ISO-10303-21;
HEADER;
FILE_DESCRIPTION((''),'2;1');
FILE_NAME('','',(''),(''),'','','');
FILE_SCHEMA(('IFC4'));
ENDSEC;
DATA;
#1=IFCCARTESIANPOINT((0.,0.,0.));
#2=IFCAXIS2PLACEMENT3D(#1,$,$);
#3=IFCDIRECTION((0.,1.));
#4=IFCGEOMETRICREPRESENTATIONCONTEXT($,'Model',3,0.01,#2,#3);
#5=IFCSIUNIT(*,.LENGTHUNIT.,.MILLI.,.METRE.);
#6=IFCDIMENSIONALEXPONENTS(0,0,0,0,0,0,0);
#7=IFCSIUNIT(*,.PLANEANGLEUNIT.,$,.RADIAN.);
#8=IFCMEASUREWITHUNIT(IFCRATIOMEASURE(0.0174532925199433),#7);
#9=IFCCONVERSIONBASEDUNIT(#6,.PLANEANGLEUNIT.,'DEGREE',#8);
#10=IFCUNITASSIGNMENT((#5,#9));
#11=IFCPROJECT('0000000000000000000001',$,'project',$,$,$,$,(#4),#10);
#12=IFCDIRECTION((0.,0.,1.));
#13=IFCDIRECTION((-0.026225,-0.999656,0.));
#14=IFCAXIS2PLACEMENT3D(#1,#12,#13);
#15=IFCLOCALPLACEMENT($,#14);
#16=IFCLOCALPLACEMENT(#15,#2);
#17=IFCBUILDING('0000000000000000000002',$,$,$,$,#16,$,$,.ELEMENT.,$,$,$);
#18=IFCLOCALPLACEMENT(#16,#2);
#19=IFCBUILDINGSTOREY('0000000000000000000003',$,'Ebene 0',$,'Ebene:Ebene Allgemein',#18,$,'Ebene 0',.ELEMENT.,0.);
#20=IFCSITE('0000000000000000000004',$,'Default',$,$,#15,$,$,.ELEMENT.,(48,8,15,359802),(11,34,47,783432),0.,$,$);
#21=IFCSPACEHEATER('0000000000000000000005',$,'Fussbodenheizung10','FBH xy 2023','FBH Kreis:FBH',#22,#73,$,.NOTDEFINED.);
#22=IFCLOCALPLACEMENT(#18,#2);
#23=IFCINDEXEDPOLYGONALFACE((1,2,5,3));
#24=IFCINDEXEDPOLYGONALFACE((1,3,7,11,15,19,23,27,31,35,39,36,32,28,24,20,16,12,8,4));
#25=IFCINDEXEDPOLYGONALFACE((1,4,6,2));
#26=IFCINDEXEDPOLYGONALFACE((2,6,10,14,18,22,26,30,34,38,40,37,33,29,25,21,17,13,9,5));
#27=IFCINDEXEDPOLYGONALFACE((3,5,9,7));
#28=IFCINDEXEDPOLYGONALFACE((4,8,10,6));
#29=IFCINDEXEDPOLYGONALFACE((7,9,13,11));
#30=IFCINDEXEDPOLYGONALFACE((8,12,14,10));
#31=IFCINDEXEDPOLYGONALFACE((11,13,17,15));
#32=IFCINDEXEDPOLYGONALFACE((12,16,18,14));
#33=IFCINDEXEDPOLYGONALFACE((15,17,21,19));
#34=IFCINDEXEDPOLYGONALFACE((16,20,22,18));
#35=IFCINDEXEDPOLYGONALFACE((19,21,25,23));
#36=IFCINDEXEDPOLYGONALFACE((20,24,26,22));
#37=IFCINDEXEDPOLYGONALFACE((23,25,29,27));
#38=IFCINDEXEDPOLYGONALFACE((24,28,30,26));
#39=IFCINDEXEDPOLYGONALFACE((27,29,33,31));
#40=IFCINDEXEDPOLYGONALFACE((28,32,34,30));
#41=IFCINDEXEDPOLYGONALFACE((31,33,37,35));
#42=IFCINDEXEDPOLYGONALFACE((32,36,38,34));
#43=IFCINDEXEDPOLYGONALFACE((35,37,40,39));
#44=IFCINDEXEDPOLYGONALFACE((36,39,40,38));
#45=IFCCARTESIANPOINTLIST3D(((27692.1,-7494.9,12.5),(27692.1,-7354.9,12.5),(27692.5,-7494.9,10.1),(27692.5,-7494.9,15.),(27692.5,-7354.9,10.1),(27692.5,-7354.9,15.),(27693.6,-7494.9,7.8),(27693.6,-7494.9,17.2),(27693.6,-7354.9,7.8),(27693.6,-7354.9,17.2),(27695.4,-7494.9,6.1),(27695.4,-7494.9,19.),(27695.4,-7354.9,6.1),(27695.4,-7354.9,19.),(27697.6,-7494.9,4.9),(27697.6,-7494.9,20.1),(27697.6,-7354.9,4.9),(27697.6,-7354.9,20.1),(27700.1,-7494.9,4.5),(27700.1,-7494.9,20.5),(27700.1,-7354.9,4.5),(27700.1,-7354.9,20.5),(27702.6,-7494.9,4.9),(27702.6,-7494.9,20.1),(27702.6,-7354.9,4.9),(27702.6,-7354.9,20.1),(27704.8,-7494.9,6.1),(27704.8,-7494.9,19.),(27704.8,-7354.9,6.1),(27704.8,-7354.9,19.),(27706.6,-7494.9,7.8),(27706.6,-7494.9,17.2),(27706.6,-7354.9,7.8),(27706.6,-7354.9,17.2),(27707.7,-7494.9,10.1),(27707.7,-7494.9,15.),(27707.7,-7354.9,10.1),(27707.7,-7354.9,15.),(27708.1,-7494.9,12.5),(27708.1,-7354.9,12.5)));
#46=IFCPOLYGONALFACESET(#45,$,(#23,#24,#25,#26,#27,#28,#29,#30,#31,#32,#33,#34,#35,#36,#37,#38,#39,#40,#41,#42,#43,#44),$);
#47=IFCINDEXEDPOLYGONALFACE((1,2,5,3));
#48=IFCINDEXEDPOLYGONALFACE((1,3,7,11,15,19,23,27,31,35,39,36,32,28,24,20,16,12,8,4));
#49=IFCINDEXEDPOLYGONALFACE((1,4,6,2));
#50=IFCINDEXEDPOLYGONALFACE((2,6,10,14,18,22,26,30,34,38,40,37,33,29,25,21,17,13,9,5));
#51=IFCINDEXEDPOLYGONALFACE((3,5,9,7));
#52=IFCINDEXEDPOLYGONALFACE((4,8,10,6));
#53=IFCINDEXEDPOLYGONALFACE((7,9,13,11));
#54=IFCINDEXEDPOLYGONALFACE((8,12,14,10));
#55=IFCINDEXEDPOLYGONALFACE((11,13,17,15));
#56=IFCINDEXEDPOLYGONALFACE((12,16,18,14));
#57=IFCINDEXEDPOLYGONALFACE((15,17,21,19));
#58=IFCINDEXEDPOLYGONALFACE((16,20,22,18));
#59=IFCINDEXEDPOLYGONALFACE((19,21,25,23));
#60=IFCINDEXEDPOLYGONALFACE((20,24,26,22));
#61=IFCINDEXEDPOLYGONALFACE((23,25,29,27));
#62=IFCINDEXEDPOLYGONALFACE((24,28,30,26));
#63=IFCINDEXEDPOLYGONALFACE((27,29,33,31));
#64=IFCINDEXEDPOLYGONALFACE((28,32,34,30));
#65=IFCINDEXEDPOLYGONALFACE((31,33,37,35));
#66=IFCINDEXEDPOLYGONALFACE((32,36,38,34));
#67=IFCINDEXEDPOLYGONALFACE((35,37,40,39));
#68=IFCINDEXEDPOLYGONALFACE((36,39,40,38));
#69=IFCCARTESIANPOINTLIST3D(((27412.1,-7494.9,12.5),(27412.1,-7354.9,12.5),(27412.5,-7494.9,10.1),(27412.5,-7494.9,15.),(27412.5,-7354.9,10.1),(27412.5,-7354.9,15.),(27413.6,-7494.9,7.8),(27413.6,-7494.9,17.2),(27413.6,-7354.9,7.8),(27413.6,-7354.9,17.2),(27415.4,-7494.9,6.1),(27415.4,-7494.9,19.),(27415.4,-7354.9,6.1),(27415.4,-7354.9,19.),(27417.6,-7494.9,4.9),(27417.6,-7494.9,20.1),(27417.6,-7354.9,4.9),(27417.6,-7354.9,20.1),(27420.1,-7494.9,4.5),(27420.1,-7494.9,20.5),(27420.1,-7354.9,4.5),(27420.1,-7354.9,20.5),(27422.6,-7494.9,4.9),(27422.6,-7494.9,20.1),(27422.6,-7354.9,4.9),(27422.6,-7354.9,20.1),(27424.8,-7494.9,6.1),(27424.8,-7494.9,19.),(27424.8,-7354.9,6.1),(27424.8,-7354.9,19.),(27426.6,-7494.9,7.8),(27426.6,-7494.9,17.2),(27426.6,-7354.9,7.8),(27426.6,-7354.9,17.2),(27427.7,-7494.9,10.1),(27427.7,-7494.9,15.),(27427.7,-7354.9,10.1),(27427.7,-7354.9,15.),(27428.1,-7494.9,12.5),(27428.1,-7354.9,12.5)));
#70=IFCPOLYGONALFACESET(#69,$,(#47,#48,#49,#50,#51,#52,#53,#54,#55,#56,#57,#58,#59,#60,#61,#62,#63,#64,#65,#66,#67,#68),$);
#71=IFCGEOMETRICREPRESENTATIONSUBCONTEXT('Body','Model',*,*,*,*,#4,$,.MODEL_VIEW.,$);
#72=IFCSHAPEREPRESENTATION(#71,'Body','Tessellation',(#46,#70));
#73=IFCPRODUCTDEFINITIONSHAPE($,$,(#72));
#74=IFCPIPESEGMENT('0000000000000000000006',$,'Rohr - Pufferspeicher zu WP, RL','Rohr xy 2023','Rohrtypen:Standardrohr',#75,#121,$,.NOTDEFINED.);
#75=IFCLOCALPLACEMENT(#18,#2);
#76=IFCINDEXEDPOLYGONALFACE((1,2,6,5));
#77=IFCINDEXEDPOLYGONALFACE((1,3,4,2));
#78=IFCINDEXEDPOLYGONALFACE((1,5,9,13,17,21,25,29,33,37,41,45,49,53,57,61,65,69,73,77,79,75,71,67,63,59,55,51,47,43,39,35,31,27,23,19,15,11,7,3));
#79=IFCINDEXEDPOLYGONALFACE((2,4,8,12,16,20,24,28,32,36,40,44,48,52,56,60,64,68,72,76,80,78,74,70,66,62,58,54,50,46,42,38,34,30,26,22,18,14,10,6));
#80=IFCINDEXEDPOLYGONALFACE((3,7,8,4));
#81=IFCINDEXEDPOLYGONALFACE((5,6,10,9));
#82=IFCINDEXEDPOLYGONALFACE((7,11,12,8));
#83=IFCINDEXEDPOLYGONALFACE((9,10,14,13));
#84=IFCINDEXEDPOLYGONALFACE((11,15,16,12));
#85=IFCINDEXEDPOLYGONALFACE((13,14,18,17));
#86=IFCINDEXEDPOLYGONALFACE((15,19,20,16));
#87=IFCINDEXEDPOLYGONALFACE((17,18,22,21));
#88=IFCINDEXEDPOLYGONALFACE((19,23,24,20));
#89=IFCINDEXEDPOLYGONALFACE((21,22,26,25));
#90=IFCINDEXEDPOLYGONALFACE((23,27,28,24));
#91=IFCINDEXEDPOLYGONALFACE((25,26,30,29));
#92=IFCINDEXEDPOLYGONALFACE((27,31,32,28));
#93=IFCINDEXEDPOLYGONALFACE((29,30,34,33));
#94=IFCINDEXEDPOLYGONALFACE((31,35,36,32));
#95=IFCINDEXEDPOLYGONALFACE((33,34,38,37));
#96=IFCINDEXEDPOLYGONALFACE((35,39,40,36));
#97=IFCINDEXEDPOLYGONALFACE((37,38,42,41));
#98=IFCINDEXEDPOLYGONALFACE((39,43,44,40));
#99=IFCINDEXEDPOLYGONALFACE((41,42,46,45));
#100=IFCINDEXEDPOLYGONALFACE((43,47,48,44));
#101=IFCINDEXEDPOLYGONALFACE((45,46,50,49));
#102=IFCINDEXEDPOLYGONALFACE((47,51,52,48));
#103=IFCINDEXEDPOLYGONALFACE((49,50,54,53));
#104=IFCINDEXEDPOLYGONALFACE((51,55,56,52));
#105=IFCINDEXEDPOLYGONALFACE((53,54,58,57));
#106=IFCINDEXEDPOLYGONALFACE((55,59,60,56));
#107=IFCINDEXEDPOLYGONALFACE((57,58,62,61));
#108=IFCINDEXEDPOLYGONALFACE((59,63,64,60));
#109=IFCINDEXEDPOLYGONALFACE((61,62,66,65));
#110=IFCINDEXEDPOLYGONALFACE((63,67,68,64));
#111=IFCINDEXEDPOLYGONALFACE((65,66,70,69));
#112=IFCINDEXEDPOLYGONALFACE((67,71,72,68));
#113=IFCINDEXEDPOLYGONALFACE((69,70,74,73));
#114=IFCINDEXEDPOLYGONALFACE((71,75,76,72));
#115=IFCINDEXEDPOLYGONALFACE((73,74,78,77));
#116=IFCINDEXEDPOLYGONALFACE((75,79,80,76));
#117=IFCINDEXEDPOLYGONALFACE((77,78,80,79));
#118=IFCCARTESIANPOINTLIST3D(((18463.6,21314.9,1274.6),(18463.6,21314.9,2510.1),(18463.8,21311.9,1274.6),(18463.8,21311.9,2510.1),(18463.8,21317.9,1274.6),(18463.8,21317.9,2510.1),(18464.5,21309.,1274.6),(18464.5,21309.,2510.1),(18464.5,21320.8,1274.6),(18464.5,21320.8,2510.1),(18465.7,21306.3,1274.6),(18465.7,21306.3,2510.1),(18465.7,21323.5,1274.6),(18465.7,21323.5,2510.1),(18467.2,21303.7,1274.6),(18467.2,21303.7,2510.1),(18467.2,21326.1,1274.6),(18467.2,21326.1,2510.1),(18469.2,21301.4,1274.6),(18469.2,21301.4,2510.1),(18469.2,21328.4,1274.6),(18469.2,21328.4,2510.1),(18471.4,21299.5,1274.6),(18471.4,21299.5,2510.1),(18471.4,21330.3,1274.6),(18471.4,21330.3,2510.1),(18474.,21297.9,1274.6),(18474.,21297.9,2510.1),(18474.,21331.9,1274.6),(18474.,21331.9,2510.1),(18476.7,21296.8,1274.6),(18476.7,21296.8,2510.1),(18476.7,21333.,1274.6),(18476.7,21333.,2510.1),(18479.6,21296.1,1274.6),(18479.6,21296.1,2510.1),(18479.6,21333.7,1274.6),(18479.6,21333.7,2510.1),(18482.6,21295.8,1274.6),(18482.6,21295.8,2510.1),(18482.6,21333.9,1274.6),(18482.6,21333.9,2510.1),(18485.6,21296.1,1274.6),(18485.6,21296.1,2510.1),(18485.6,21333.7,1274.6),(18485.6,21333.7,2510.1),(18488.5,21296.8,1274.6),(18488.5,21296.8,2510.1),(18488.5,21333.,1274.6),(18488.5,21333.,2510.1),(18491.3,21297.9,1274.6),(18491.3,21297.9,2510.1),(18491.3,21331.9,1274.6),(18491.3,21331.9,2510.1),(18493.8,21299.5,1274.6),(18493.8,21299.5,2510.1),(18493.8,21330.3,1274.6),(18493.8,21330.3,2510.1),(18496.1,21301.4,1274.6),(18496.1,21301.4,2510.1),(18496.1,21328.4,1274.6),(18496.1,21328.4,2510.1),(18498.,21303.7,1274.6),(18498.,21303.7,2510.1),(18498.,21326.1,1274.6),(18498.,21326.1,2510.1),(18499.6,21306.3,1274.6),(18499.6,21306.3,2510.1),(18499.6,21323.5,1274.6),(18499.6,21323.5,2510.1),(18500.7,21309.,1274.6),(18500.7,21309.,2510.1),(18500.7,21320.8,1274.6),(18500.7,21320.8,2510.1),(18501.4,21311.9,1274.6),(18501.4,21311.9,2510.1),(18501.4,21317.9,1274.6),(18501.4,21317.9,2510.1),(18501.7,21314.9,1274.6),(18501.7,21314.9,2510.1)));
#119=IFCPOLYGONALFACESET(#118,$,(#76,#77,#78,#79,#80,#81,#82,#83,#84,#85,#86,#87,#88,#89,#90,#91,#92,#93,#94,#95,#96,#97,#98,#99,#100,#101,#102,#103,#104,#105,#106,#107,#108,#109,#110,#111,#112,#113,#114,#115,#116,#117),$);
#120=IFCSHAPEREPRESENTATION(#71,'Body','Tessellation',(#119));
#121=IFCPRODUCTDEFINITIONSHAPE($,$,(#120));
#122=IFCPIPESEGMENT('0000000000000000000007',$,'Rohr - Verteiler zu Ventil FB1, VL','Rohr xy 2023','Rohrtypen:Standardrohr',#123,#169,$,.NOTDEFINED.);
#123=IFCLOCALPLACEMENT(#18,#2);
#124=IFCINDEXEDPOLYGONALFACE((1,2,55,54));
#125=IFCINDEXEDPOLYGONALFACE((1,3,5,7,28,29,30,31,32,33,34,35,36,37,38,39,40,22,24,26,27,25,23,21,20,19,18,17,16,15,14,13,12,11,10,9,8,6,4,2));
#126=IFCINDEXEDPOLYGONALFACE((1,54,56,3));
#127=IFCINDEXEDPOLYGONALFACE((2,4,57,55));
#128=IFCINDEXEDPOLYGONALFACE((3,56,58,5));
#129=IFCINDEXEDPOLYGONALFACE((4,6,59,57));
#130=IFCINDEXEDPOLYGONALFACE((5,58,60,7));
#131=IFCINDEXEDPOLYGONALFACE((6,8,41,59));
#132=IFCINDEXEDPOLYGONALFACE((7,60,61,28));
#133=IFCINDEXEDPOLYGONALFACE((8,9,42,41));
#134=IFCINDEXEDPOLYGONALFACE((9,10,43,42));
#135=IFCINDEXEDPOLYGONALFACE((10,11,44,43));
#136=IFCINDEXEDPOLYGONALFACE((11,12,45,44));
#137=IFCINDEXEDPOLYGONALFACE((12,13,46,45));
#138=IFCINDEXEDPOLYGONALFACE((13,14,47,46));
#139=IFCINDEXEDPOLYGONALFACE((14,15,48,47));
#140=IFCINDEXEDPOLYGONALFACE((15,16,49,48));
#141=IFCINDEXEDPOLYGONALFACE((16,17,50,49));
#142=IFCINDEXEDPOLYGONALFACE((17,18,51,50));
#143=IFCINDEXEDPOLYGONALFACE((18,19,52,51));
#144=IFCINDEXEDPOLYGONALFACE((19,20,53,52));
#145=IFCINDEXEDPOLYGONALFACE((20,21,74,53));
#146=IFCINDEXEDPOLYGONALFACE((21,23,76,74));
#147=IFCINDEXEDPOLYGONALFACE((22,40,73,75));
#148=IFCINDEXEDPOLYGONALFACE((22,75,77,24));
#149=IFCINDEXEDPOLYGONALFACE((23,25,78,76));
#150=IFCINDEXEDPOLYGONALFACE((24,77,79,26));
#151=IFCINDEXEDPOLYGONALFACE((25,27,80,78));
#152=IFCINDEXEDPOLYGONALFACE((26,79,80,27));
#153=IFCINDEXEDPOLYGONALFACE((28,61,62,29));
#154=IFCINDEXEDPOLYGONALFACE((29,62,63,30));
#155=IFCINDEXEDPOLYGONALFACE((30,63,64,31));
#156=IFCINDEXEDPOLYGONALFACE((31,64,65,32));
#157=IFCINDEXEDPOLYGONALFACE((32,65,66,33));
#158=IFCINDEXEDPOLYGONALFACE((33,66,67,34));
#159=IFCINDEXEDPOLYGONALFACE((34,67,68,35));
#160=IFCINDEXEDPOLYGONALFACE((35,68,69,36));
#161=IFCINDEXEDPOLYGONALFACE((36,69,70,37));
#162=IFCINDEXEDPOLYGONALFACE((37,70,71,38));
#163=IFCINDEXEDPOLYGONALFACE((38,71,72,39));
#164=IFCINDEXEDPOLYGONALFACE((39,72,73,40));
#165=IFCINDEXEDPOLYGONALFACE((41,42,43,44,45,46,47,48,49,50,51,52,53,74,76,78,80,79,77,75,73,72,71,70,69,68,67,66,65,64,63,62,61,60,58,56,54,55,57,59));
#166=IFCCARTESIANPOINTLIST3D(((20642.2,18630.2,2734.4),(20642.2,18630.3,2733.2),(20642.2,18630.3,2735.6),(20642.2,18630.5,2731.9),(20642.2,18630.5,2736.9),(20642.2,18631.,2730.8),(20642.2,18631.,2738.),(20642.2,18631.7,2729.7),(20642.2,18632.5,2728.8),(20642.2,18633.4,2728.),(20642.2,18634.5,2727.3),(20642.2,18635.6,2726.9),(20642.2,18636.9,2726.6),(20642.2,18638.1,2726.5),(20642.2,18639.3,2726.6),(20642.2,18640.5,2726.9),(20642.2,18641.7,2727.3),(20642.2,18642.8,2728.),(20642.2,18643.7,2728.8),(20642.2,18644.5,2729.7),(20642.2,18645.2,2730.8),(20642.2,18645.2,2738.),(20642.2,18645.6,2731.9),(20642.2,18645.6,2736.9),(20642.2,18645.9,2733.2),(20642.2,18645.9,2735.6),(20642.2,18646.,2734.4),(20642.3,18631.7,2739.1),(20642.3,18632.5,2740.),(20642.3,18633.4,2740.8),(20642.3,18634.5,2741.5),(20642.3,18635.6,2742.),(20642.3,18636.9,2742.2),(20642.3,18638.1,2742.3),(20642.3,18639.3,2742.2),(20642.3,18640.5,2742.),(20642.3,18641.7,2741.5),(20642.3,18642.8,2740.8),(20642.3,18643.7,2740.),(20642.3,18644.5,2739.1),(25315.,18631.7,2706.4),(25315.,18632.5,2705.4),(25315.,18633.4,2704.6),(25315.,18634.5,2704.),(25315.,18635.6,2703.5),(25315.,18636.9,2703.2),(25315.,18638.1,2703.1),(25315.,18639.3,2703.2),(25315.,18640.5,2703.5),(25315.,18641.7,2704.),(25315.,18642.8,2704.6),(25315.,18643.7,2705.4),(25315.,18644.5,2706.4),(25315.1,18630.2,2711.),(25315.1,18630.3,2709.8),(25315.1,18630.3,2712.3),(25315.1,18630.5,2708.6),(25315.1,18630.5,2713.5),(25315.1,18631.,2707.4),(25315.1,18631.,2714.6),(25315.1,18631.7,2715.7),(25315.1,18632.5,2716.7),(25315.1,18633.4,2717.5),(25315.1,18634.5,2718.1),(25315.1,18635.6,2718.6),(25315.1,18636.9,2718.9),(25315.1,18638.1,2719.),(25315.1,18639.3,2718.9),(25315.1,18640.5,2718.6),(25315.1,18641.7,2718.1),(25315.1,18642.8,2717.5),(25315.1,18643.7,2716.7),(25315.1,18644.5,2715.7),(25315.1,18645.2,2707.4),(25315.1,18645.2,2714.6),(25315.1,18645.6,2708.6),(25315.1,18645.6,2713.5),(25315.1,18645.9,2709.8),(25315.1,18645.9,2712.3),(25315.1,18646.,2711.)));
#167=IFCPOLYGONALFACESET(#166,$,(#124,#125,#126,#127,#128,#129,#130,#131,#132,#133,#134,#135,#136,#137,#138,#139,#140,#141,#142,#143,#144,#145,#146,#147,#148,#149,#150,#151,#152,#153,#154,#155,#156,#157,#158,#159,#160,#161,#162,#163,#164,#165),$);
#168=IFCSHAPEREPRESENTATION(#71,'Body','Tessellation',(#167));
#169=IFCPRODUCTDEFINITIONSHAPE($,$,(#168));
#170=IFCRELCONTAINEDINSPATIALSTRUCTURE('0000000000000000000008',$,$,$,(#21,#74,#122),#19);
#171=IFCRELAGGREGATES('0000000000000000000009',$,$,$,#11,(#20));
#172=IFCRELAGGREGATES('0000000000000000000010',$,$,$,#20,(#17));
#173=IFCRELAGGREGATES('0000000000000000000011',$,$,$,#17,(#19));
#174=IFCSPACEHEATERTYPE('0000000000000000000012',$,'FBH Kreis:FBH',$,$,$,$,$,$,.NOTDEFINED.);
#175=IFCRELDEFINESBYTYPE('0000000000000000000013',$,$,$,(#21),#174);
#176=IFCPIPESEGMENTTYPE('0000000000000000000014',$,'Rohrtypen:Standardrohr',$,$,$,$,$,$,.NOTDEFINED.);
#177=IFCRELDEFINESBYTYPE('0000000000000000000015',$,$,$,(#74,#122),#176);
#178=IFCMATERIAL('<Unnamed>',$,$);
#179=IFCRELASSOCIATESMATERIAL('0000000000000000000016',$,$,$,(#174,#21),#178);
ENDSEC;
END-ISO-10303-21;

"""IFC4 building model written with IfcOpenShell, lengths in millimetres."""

from ifc_helpers import new_model, entity, si_unit, converted_unit, direction, frame, origin, place, context, subcontext, project, spatial, indexed_curve, outline, extrude, source, transform, mapped, material, type_object, type_shapes, element, save


model = new_model("IFC4")

# Units and contexts
model_context = context("Model", 3, precision=0.01, world=origin(), true_north=direction((0.0, 1.0)))
body_context = subcontext(model_context, "Body", "Model", "MODEL_VIEW")
ifc_project = project(units=[si_unit("LENGTHUNIT", "METRE", prefix="MILLI"), converted_unit("PLANEANGLEUNIT", "DEGREE", entity("IfcRatioMeasure", 0.0174532925199433), si_unit("PLANEANGLEUNIT", "RADIAN"), dimensions=[0, 0, 0, 0, 0, 0, 0])], contexts=[model_context])

# Site, building, storey
site_placement = place(None, frame((0.0, 0.0, 0.0), z_axis=(0.0, 0.0, 1.0), x_axis=(-0.026225, -0.999656, 0.0)))
site = spatial("IfcSite", under=ifc_project, at=site_placement, Name="Default", CompositionType="ELEMENT", RefLatitude=(48, 8, 15, 359802), RefLongitude=(11, 34, 47, 783432), RefElevation=0.0)
building_placement = place(site_placement, origin())
building = spatial("IfcBuilding", under=site, at=building_placement, CompositionType="ELEMENT")
storey_placement = place(building_placement, origin())
storey = spatial("IfcBuildingStorey", under=building, at=storey_placement, Name="Ebene 0", ObjectType="Ebene:Ebene Allgemein", LongName="Ebene 0", CompositionType="ELEMENT", Elevation=0.0)

# Space heater
ifc_material = material(Name="<Unnamed>")
space_heater_type = type_object("IfcSpaceHeaterType", Name="FBH Kreis:FBH", PredefinedType="NOTDEFINED", material=ifc_material)
shared_shape = source(origin(), body_context, "Body", "SweptSolid", [
    extrude(outline(indexed_curve([(8.0, 0.0), (7.6, 2.5), (6.5, 4.7), (4.7, 6.5), (2.5, 7.6), (0.0, 8.0), (-2.5, 7.6), (-4.7, 6.5), (-6.5, 4.7), (-7.6, 2.5), (-8.0, 0.0), (-7.6, -2.5), (-6.5, -4.7), (-4.7, -6.5), (-2.5, -7.6), (0.0, -8.0), (2.5, -7.6), (4.7, -6.5), (6.5, -4.7), (7.6, -2.5), (8.0, 0.0)], self_intersect=False)), frame((140.0, -1621.8, -83.0), z_axis=(0.0, 1.0, 0.0), x_axis=(1.0, 0.0, 0.0)), (0.0, 0.0, 1.0), 140.0),
    extrude(outline(indexed_curve([(8.0, 0.0), (7.6, 2.5), (6.5, 4.7), (4.7, 6.5), (2.5, 7.6), (0.0, 8.0), (-2.5, 7.6), (-4.7, 6.5), (-6.5, 4.7), (-7.6, 2.5), (-8.0, 0.0), (-7.6, -2.5), (-6.5, -4.7), (-4.7, -6.5), (-2.5, -7.6), (0.0, -8.0), (2.5, -7.6), (4.7, -6.5), (6.5, -4.7), (7.6, -2.5), (8.0, 0.0)], self_intersect=False)), frame((-140.0, -1621.8, -83.0), z_axis=(0.0, 1.0, 0.0), x_axis=(1.0, 0.0, 0.0)), (0.0, 0.0, 1.0), 140.0),
])
type_shapes(space_heater_type, [shared_shape])
for number, where, name in (
    (1, (27560.1, -5873.1, 95.5), "Fussbodenheizung10"),
):
    element("IfcSpaceHeater", number, at=place(storey_placement, frame(where)), inside=storey, type_object=space_heater_type, material=ifc_material, Name=name, Description="FBH xy 2023", ObjectType="FBH Kreis:FBH", PredefinedType="NOTDEFINED", context=body_context, shape_type="MappedRepresentation", body=[
        mapped(shared_shape, transform((0.0, 0.0, 0.0), scale=1.0)),
    ])

# Pipe segments
pipe_segment_type = type_object("IfcPipeSegmentType", Name="Rohrtypen:Standardrohr", PredefinedType="NOTDEFINED")
pipe_segment_1_placement = place(storey_placement, origin())
element("IfcPipeSegment", 2, at=pipe_segment_1_placement, inside=storey, type_object=pipe_segment_type, Name="Rohr - Pufferspeicher zu WP, RL", Description="Rohr xy 2023", ObjectType="Rohrtypen:Standardrohr", PredefinedType="NOTDEFINED", context=body_context, shape_type="SweptSolid", body=[
    extrude(outline(indexed_curve([(19.1, 0.0), (18.8, 3.0), (18.1, 5.9), (17.0, 8.6), (15.4, 11.2), (13.5, 13.5), (11.2, 15.4), (8.6, 17.0), (5.9, 18.1), (3.0, 18.8), (0.0, 19.1), (-3.0, 18.8), (-5.9, 18.1), (-8.6, 17.0), (-11.2, 15.4), (-13.5, 13.5), (-15.4, 11.2), (-17.0, 8.6), (-18.1, 5.9), (-18.8, 3.0), (-19.1, 0.0), (-18.8, -3.0), (-18.1, -5.9), (-17.0, -8.6), (-15.4, -11.2), (-13.5, -13.5), (-11.2, -15.4), (-8.6, -17.0), (-5.9, -18.1), (-3.0, -18.8), (0.0, -19.1), (3.0, -18.8), (5.9, -18.1), (8.6, -17.0), (11.2, -15.4), (13.5, -13.5), (15.4, -11.2), (17.0, -8.6), (18.1, -5.9), (18.8, -3.0), (19.1, 0.0)], self_intersect=False)), frame((18482.6, 21314.9, 1274.6), z_axis=(0.0, 0.0, 1.0), x_axis=(-1.0, 0.0, 0.0)), (0.0, 0.0, 1.0), 1235.5),
])
pipe_segment_2_placement = place(storey_placement, origin())
element("IfcPipeSegment", 3, at=pipe_segment_2_placement, inside=storey, type_object=pipe_segment_type, Name="Rohr - Verteiler zu Ventil FB1, VL", Description="Rohr xy 2023", ObjectType="Rohrtypen:Standardrohr", PredefinedType="NOTDEFINED", context=body_context, shape_type="SweptSolid", body=[
    extrude(outline(indexed_curve([(7.9, 0.0), (7.8, 1.2), (7.6, 2.5), (7.1, 3.6), (6.4, 4.7), (5.6, 5.6), (4.7, 6.4), (3.6, 7.1), (2.5, 7.6), (1.2, 7.8), (0.0, 7.9), (-1.2, 7.8), (-2.5, 7.6), (-3.6, 7.1), (-4.7, 6.4), (-5.6, 5.6), (-6.4, 4.7), (-7.1, 3.6), (-7.6, 2.5), (-7.8, 1.2), (-7.9, 0.0), (-7.8, -1.2), (-7.6, -2.5), (-7.1, -3.6), (-6.4, -4.7), (-5.6, -5.6), (-4.7, -6.4), (-3.6, -7.1), (-2.5, -7.6), (-1.2, -7.8), (0.0, -7.9), (1.2, -7.8), (2.5, -7.6), (3.6, -7.1), (4.7, -6.4), (5.6, -5.6), (6.4, -4.7), (7.1, -3.6), (7.6, -2.5), (7.8, -1.2), (7.9, 0.0)], self_intersect=False)), frame((25315.1, 18638.1, 2711.0), z_axis=(-0.999988, 0.0, 0.005), x_axis=(0.0, 1.0, 0.0)), (0.0, 0.0, 1.0), 4672.9),
])

save(model, "model.ifc")
